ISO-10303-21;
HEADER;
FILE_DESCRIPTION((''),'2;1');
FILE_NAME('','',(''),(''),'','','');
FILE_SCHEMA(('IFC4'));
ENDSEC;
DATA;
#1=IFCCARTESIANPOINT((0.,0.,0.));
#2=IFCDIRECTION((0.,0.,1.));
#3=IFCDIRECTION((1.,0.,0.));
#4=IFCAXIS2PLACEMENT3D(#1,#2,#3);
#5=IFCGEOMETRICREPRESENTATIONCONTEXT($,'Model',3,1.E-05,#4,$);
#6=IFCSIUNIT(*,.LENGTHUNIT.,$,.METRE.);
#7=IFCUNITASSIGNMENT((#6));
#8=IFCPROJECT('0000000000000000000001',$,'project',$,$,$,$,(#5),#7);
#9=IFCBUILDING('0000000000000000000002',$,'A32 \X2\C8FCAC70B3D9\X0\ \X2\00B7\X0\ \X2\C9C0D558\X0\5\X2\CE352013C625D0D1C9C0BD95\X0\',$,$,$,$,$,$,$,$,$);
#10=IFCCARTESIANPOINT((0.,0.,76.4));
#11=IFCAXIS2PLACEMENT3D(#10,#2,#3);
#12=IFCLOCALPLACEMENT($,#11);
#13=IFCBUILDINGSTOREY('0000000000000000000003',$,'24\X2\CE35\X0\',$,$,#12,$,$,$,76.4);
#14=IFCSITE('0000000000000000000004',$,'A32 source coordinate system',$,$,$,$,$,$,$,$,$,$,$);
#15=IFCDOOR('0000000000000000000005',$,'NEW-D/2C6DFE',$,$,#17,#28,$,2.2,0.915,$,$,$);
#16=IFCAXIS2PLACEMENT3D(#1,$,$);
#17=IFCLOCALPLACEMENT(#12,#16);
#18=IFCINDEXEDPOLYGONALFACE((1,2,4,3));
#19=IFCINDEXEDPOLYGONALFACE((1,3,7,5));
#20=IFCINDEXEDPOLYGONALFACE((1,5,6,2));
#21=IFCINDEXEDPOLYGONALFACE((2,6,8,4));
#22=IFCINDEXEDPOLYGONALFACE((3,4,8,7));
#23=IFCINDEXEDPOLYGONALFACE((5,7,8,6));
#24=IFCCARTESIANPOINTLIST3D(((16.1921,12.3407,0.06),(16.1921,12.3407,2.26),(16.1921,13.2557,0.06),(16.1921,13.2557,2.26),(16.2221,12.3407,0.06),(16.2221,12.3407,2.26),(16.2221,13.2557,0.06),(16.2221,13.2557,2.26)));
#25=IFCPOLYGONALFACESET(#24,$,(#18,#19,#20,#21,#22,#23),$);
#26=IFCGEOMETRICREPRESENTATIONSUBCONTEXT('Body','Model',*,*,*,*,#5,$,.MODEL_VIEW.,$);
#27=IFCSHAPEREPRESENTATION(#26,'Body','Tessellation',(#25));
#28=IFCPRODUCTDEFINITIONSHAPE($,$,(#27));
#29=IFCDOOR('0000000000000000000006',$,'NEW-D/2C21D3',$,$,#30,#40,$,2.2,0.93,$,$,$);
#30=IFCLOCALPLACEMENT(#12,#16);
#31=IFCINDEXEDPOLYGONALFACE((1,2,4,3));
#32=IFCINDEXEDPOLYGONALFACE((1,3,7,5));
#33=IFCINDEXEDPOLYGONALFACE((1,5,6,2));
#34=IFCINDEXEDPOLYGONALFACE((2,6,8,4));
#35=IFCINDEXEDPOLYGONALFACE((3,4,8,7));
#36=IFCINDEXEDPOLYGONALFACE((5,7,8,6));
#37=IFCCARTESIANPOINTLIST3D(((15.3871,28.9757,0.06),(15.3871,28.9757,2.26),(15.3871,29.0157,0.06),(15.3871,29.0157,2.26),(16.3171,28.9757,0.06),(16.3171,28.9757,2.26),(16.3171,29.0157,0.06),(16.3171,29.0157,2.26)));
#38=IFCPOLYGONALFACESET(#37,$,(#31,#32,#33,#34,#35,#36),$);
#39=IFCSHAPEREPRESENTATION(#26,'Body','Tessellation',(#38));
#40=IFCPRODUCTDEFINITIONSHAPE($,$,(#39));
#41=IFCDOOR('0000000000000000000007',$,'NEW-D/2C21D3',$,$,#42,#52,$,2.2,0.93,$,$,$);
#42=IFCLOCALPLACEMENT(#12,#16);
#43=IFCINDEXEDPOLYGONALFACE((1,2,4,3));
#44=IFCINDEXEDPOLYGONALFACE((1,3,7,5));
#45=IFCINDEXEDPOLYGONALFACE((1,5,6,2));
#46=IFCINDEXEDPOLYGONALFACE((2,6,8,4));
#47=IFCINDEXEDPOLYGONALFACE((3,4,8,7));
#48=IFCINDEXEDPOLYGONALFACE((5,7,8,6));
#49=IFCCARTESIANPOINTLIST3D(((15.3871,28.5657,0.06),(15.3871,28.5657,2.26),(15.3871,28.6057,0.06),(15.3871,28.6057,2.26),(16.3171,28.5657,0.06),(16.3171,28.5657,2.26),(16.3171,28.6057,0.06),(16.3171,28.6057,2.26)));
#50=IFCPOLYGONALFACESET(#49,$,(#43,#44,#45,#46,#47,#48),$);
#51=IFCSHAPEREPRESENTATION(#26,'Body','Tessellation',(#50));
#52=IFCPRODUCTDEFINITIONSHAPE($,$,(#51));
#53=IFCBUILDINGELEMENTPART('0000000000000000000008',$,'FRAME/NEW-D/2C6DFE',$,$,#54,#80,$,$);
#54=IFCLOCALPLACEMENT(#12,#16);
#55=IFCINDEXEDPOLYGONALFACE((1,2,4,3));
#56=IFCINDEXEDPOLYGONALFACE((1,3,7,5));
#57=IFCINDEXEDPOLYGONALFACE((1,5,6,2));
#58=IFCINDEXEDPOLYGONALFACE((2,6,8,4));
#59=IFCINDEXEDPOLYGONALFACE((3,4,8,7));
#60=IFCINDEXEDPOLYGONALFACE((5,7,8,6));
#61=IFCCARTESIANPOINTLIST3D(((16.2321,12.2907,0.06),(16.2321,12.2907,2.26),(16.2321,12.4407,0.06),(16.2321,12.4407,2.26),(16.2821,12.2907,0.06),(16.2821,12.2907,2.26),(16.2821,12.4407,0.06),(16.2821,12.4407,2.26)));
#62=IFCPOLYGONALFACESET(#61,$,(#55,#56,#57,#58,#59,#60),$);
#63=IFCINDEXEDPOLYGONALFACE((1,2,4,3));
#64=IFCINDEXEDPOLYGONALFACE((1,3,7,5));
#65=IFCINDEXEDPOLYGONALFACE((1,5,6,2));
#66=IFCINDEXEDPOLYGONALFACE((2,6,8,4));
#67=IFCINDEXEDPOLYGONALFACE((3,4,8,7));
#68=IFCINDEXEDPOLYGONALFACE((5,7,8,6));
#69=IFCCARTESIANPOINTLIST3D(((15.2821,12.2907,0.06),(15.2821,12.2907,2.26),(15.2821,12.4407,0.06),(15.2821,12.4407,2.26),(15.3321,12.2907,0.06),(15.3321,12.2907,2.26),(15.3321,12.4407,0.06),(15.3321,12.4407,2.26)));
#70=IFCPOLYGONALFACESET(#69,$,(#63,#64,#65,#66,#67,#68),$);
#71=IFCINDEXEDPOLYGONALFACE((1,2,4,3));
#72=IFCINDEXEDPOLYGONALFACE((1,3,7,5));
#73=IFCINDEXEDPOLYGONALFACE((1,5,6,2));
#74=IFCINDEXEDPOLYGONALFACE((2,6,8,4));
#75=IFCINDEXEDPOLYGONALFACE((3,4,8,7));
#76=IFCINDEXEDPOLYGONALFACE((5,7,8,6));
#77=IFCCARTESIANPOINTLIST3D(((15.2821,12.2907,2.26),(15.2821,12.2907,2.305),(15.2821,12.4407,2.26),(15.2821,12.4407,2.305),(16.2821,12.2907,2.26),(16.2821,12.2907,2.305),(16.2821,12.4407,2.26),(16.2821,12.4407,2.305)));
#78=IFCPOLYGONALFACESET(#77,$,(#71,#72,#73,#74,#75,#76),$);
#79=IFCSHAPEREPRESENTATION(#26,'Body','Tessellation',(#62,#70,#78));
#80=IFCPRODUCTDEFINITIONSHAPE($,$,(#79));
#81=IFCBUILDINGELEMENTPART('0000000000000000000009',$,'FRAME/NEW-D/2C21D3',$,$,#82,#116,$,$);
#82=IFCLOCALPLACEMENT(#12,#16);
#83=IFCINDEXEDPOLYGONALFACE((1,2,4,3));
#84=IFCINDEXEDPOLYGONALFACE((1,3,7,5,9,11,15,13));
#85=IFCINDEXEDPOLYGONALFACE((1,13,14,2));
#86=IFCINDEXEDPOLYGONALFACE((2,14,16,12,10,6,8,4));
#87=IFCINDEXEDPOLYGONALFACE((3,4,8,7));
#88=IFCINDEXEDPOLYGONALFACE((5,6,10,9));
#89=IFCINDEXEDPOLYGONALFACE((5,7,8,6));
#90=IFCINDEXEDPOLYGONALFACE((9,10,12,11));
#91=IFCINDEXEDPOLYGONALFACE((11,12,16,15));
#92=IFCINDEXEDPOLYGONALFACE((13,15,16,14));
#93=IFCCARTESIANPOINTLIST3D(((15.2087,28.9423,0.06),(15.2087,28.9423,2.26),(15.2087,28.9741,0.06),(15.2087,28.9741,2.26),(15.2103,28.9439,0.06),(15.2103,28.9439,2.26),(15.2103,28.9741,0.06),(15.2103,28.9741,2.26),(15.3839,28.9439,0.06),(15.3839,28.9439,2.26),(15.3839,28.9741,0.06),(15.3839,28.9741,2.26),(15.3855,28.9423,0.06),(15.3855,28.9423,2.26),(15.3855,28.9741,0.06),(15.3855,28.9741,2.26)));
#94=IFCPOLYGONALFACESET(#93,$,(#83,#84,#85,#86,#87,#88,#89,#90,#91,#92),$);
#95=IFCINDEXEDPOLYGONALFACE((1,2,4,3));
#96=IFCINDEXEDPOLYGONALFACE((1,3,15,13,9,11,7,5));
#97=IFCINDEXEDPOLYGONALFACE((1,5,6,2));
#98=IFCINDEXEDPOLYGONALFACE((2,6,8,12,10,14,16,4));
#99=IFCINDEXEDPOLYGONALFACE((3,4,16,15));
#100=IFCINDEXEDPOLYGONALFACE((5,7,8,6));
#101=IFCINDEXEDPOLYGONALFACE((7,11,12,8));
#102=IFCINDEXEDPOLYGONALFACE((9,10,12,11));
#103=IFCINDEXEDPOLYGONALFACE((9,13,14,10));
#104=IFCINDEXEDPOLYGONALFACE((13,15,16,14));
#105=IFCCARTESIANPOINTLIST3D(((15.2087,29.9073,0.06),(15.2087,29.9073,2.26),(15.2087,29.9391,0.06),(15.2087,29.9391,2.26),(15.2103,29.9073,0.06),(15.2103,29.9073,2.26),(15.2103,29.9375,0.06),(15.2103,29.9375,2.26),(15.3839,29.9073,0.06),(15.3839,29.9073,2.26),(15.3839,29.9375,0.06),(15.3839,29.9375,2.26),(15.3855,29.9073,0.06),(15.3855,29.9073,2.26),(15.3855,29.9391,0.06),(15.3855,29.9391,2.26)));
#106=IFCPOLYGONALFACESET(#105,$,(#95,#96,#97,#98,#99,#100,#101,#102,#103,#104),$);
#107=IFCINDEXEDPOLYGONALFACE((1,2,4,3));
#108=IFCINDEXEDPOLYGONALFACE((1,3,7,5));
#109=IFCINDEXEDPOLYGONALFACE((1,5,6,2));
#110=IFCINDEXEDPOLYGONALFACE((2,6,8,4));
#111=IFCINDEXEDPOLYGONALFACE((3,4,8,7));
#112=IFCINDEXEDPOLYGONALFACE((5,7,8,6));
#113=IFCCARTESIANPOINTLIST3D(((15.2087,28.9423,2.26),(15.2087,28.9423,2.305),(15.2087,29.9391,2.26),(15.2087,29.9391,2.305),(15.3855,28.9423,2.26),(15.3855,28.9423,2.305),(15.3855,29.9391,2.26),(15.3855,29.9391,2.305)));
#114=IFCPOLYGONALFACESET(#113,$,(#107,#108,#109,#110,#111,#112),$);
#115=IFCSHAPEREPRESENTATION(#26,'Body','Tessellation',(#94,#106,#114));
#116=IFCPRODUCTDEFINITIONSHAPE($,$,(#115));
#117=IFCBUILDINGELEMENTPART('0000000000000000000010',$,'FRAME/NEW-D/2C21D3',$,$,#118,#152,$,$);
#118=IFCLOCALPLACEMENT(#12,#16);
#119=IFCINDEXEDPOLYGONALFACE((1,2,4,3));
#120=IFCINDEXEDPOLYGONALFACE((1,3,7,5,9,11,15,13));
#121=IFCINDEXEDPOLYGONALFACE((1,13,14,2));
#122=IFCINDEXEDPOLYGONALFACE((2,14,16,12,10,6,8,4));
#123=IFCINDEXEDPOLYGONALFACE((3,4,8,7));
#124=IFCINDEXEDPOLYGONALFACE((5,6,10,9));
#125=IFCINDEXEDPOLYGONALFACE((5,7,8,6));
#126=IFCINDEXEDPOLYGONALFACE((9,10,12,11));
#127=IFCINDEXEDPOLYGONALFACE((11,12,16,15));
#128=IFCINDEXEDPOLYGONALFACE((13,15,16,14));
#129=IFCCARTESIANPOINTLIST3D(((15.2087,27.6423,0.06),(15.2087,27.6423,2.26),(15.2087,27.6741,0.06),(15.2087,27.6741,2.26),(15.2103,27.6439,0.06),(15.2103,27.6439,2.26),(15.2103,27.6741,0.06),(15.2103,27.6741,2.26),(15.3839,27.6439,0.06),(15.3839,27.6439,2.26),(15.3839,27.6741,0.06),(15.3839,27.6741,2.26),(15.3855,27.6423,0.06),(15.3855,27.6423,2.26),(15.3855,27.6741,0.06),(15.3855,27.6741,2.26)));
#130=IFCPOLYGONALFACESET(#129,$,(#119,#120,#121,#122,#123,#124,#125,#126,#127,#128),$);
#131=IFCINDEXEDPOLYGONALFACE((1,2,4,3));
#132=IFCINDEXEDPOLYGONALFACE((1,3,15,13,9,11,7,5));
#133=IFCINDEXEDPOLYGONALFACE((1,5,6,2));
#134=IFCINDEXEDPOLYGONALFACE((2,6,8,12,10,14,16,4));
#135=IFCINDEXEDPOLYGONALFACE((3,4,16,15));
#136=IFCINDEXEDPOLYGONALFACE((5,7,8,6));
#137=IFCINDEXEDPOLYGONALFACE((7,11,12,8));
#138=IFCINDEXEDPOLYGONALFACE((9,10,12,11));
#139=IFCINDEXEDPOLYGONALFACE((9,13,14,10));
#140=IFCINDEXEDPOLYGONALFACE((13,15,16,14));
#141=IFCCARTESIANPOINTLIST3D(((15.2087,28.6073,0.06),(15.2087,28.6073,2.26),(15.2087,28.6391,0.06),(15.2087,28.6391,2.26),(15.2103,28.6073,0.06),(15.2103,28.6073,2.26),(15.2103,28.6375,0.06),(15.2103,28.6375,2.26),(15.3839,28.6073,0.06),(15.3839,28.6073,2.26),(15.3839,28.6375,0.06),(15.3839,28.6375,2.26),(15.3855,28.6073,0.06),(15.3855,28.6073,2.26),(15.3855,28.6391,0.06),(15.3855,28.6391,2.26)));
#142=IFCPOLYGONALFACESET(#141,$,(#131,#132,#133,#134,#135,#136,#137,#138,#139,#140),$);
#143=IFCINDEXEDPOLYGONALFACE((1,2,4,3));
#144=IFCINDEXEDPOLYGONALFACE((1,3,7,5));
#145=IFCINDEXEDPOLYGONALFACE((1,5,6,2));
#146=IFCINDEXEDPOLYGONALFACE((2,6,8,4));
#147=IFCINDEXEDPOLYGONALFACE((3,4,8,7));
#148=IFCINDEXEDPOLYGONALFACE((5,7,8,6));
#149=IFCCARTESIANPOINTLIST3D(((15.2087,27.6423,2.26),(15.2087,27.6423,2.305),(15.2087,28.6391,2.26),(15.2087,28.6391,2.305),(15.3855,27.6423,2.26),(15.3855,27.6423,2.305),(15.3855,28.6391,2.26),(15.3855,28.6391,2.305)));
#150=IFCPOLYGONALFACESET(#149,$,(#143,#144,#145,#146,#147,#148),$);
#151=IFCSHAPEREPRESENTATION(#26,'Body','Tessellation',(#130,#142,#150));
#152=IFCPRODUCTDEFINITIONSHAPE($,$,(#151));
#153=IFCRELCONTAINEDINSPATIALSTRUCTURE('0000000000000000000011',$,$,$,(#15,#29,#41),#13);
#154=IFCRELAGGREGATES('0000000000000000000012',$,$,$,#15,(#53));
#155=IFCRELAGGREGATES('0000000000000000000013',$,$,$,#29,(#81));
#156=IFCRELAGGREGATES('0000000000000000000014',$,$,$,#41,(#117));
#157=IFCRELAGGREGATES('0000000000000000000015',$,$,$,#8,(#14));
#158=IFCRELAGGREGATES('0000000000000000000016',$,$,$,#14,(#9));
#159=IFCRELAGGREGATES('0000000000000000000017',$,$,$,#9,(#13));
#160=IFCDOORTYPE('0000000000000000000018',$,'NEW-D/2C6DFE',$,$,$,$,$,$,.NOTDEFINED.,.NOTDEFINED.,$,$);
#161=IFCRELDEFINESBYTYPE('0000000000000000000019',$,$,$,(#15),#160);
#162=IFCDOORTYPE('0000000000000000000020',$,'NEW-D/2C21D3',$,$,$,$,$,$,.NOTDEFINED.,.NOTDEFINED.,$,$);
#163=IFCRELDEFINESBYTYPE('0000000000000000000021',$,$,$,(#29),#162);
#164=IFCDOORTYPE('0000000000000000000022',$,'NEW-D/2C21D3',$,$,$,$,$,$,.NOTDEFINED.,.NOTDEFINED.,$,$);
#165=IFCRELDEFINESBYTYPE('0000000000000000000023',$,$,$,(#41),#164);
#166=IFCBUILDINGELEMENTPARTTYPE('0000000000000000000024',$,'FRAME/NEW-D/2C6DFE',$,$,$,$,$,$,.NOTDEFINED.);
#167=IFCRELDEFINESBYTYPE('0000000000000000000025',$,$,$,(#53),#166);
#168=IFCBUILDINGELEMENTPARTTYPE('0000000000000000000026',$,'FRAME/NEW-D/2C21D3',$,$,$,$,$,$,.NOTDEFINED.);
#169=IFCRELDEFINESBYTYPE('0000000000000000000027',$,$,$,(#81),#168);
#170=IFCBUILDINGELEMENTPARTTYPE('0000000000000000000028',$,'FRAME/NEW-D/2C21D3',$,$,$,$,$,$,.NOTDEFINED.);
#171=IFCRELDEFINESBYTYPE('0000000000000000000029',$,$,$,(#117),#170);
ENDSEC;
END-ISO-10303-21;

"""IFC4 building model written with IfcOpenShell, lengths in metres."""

from ifc_helpers import new_model, si_unit, frame, origin, origin_with_axes, place, context, subcontext, project, spatial, polyline, outline, extrude, source, transform, mapped, type_object, type_shapes, element, aggregate, save


model = new_model("IFC4")

# Units and contexts
model_context = context("Model", 3, precision=1e-05, world=origin_with_axes())
body_context = subcontext(model_context, "Body", "Model", "MODEL_VIEW")
ifc_project = project(units=[si_unit("LENGTHUNIT", "METRE")], contexts=[model_context])

# Site, building, storey
site = spatial("IfcSite", under=ifc_project, Name="A32 source coordinate system")
building = spatial("IfcBuilding", under=site, Name="A32 주거동 · 지하5층–옥탑지붕")
storey_placement = place(None, frame((0.0, 0.0, 76.4), z_axis=(0.0, 0.0, 1.0), x_axis=(1.0, 0.0, 0.0)))
storey = spatial("IfcBuildingStorey", under=building, at=storey_placement, Name="24층", Elevation=76.4)

# Doors
door_type_1 = type_object("IfcDoorType", Name="NEW-D/2C6DFE", OperationType="NOTDEFINED", PredefinedType="NOTDEFINED")
shared_shape_1 = source(origin(), body_context, "Body", "SweptSolid", [
    extrude(outline(polyline([(16.1921, 12.3407), (16.1921, 13.2557), (16.2221, 13.2557), (16.2221, 12.3407), (16.1921, 12.3407)])), frame((0.0, 0.0, 0.06)), (0.0, 0.0, 1.0), 2.2),
])
type_shapes(door_type_1, [shared_shape_1])
door_1_placement = place(storey_placement, origin_with_axes())
door_1 = element("IfcDoor", 1, at=door_1_placement, inside=storey, type_object=door_type_1, Name="NEW-D/2C6DFE", OverallHeight=2.2, OverallWidth=0.915, context=body_context, shape_type="MappedRepresentation", body=[
    mapped(shared_shape_1, transform((0.0, 0.0, 0.0), scale=1.0)),
])
door_type_2 = type_object("IfcDoorType", Name="NEW-D/2C21D3", OperationType="NOTDEFINED", PredefinedType="NOTDEFINED")
shared_shape_2 = source(origin(), body_context, "Body", "SweptSolid", [
    extrude(outline(polyline([(15.3871, 28.9757), (15.3871, 29.0157), (16.3171, 29.0157), (16.3171, 28.9757), (15.3871, 28.9757)])), frame((0.0, 0.0, 0.06)), (0.0, 0.0, 1.0), 2.2),
])
type_shapes(door_type_2, [shared_shape_2])
door_2_placement = place(storey_placement, origin_with_axes())
door_2 = element("IfcDoor", 2, at=door_2_placement, inside=storey, type_object=door_type_2, Name="NEW-D/2C21D3", OverallHeight=2.2, OverallWidth=0.93, context=body_context, shape_type="MappedRepresentation", body=[
    mapped(shared_shape_2, transform((0.0, 0.0, 0.0), scale=1.0)),
])
door_type_3 = type_object("IfcDoorType", Name="NEW-D/2C21D3", OperationType="NOTDEFINED", PredefinedType="NOTDEFINED")
shared_shape_3 = source(origin(), body_context, "Body", "SweptSolid", [
    extrude(outline(polyline([(16.3171, 28.5657), (15.3871, 28.5657), (15.3871, 28.6057), (16.3171, 28.6057), (16.3171, 28.5657)])), frame((0.0, 0.0, 0.06)), (0.0, 0.0, 1.0), 2.2),
])
type_shapes(door_type_3, [shared_shape_3])
door_3_placement = place(storey_placement, origin_with_axes())
door_3 = element("IfcDoor", 3, at=door_3_placement, inside=storey, type_object=door_type_3, Name="NEW-D/2C21D3", OverallHeight=2.2, OverallWidth=0.93, context=body_context, shape_type="MappedRepresentation", body=[
    mapped(shared_shape_3, transform((0.0, 0.0, 0.0), scale=1.0)),
])

# Building element parts
building_element_part_type_1 = type_object("IfcBuildingElementPartType", Name="FRAME/NEW-D/2C6DFE", PredefinedType="NOTDEFINED")
shared_shape_4 = source(origin(), body_context, "Body", "SweptSolid", [
    extrude(outline(polyline([(16.2321, 12.4407), (16.2821, 12.4407), (16.2821, 12.2907), (16.2321, 12.2907), (16.2321, 12.4407)])), frame((0.0, 0.0, 0.06)), (0.0, 0.0, 1.0), 2.2),
    extrude(outline(polyline([(15.2821, 12.4407), (15.3321, 12.4407), (15.3321, 12.2907), (15.2821, 12.2907), (15.2821, 12.4407)])), frame((0.0, 0.0, 0.06)), (0.0, 0.0, 1.0), 2.2),
    extrude(outline(polyline([(16.2821, 12.2907), (16.2821, 12.4407), (15.2821, 12.4407), (15.2821, 12.2907), (16.2821, 12.2907)])), frame((0.0, 0.0, 2.26)), (0.0, 0.0, 1.0), 0.045),
])
type_shapes(building_element_part_type_1, [shared_shape_4])
building_element_part_1_placement = place(door_1_placement, origin_with_axes())
building_element_part_1 = element("IfcBuildingElementPart", 4, at=building_element_part_1_placement, type_object=building_element_part_type_1, Name="FRAME/NEW-D/2C6DFE", context=body_context, shape_type="MappedRepresentation", body=[
    mapped(shared_shape_4, transform((0.0, 0.0, 0.0), scale=1.0)),
])
aggregate(door_1, [building_element_part_1])
building_element_part_type_2 = type_object("IfcBuildingElementPartType", Name="FRAME/NEW-D/2C21D3", PredefinedType="NOTDEFINED")
shared_shape_5 = source(origin(), body_context, "Body", "SweptSolid", [
    extrude(outline(polyline([(15.2087, 28.9423), (15.2087, 28.9741), (15.2103, 28.9741), (15.2103, 28.9439), (15.3839, 28.9439), (15.3839, 28.9741), (15.3855, 28.9741), (15.3855, 28.9423), (15.2087, 28.9423)])), frame((0.0, 0.0, 0.06)), (0.0, 0.0, 1.0), 2.2),
    extrude(outline(polyline([(15.3839, 29.9375), (15.2103, 29.9375), (15.2103, 29.9073), (15.2087, 29.9073), (15.2087, 29.9391), (15.3855, 29.9391), (15.3855, 29.9073), (15.3839, 29.9073), (15.3839, 29.9375)])), frame((0.0, 0.0, 0.06)), (0.0, 0.0, 1.0), 2.2),
    extrude(outline(polyline([(15.3855, 28.9423), (15.3855, 29.9391), (15.2087, 29.9391), (15.2087, 28.9423), (15.3855, 28.9423)])), frame((0.0, 0.0, 2.26)), (0.0, 0.0, 1.0), 0.045),
])
type_shapes(building_element_part_type_2, [shared_shape_5])
building_element_part_2_placement = place(door_2_placement, origin_with_axes())
building_element_part_2 = element("IfcBuildingElementPart", 5, at=building_element_part_2_placement, type_object=building_element_part_type_2, Name="FRAME/NEW-D/2C21D3", context=body_context, shape_type="MappedRepresentation", body=[
    mapped(shared_shape_5, transform((0.0, 0.0, 0.0), scale=1.0)),
])
aggregate(door_2, [building_element_part_2])
building_element_part_type_3 = type_object("IfcBuildingElementPartType", Name="FRAME/NEW-D/2C21D3", PredefinedType="NOTDEFINED")
shared_shape_6 = source(origin(), body_context, "Body", "SweptSolid", [
    extrude(outline(polyline([(15.2087, 27.6423), (15.2087, 27.6741), (15.2103, 27.6741), (15.2103, 27.6439), (15.3839, 27.6439), (15.3839, 27.6741), (15.3855, 27.6741), (15.3855, 27.6423), (15.2087, 27.6423)])), frame((0.0, 0.0, 0.06)), (0.0, 0.0, 1.0), 2.2),
    extrude(outline(polyline([(15.3839, 28.6375), (15.2103, 28.6375), (15.2103, 28.6073), (15.2087, 28.6073), (15.2087, 28.6391), (15.3855, 28.6391), (15.3855, 28.6073), (15.3839, 28.6073), (15.3839, 28.6375)])), frame((0.0, 0.0, 0.06)), (0.0, 0.0, 1.0), 2.2),
    extrude(outline(polyline([(15.3855, 27.6423), (15.3855, 28.6391), (15.2087, 28.6391), (15.2087, 27.6423), (15.3855, 27.6423)])), frame((0.0, 0.0, 2.26)), (0.0, 0.0, 1.0), 0.045),
])
type_shapes(building_element_part_type_3, [shared_shape_6])
building_element_part_3_placement = place(door_3_placement, origin_with_axes())
building_element_part_3 = element("IfcBuildingElementPart", 6, at=building_element_part_3_placement, type_object=building_element_part_type_3, Name="FRAME/NEW-D/2C21D3", context=body_context, shape_type="MappedRepresentation", body=[
    mapped(shared_shape_6, transform((0.0, 0.0, 0.0), scale=1.0)),
])
aggregate(door_3, [building_element_part_3])

save(model, "model.ifc")
